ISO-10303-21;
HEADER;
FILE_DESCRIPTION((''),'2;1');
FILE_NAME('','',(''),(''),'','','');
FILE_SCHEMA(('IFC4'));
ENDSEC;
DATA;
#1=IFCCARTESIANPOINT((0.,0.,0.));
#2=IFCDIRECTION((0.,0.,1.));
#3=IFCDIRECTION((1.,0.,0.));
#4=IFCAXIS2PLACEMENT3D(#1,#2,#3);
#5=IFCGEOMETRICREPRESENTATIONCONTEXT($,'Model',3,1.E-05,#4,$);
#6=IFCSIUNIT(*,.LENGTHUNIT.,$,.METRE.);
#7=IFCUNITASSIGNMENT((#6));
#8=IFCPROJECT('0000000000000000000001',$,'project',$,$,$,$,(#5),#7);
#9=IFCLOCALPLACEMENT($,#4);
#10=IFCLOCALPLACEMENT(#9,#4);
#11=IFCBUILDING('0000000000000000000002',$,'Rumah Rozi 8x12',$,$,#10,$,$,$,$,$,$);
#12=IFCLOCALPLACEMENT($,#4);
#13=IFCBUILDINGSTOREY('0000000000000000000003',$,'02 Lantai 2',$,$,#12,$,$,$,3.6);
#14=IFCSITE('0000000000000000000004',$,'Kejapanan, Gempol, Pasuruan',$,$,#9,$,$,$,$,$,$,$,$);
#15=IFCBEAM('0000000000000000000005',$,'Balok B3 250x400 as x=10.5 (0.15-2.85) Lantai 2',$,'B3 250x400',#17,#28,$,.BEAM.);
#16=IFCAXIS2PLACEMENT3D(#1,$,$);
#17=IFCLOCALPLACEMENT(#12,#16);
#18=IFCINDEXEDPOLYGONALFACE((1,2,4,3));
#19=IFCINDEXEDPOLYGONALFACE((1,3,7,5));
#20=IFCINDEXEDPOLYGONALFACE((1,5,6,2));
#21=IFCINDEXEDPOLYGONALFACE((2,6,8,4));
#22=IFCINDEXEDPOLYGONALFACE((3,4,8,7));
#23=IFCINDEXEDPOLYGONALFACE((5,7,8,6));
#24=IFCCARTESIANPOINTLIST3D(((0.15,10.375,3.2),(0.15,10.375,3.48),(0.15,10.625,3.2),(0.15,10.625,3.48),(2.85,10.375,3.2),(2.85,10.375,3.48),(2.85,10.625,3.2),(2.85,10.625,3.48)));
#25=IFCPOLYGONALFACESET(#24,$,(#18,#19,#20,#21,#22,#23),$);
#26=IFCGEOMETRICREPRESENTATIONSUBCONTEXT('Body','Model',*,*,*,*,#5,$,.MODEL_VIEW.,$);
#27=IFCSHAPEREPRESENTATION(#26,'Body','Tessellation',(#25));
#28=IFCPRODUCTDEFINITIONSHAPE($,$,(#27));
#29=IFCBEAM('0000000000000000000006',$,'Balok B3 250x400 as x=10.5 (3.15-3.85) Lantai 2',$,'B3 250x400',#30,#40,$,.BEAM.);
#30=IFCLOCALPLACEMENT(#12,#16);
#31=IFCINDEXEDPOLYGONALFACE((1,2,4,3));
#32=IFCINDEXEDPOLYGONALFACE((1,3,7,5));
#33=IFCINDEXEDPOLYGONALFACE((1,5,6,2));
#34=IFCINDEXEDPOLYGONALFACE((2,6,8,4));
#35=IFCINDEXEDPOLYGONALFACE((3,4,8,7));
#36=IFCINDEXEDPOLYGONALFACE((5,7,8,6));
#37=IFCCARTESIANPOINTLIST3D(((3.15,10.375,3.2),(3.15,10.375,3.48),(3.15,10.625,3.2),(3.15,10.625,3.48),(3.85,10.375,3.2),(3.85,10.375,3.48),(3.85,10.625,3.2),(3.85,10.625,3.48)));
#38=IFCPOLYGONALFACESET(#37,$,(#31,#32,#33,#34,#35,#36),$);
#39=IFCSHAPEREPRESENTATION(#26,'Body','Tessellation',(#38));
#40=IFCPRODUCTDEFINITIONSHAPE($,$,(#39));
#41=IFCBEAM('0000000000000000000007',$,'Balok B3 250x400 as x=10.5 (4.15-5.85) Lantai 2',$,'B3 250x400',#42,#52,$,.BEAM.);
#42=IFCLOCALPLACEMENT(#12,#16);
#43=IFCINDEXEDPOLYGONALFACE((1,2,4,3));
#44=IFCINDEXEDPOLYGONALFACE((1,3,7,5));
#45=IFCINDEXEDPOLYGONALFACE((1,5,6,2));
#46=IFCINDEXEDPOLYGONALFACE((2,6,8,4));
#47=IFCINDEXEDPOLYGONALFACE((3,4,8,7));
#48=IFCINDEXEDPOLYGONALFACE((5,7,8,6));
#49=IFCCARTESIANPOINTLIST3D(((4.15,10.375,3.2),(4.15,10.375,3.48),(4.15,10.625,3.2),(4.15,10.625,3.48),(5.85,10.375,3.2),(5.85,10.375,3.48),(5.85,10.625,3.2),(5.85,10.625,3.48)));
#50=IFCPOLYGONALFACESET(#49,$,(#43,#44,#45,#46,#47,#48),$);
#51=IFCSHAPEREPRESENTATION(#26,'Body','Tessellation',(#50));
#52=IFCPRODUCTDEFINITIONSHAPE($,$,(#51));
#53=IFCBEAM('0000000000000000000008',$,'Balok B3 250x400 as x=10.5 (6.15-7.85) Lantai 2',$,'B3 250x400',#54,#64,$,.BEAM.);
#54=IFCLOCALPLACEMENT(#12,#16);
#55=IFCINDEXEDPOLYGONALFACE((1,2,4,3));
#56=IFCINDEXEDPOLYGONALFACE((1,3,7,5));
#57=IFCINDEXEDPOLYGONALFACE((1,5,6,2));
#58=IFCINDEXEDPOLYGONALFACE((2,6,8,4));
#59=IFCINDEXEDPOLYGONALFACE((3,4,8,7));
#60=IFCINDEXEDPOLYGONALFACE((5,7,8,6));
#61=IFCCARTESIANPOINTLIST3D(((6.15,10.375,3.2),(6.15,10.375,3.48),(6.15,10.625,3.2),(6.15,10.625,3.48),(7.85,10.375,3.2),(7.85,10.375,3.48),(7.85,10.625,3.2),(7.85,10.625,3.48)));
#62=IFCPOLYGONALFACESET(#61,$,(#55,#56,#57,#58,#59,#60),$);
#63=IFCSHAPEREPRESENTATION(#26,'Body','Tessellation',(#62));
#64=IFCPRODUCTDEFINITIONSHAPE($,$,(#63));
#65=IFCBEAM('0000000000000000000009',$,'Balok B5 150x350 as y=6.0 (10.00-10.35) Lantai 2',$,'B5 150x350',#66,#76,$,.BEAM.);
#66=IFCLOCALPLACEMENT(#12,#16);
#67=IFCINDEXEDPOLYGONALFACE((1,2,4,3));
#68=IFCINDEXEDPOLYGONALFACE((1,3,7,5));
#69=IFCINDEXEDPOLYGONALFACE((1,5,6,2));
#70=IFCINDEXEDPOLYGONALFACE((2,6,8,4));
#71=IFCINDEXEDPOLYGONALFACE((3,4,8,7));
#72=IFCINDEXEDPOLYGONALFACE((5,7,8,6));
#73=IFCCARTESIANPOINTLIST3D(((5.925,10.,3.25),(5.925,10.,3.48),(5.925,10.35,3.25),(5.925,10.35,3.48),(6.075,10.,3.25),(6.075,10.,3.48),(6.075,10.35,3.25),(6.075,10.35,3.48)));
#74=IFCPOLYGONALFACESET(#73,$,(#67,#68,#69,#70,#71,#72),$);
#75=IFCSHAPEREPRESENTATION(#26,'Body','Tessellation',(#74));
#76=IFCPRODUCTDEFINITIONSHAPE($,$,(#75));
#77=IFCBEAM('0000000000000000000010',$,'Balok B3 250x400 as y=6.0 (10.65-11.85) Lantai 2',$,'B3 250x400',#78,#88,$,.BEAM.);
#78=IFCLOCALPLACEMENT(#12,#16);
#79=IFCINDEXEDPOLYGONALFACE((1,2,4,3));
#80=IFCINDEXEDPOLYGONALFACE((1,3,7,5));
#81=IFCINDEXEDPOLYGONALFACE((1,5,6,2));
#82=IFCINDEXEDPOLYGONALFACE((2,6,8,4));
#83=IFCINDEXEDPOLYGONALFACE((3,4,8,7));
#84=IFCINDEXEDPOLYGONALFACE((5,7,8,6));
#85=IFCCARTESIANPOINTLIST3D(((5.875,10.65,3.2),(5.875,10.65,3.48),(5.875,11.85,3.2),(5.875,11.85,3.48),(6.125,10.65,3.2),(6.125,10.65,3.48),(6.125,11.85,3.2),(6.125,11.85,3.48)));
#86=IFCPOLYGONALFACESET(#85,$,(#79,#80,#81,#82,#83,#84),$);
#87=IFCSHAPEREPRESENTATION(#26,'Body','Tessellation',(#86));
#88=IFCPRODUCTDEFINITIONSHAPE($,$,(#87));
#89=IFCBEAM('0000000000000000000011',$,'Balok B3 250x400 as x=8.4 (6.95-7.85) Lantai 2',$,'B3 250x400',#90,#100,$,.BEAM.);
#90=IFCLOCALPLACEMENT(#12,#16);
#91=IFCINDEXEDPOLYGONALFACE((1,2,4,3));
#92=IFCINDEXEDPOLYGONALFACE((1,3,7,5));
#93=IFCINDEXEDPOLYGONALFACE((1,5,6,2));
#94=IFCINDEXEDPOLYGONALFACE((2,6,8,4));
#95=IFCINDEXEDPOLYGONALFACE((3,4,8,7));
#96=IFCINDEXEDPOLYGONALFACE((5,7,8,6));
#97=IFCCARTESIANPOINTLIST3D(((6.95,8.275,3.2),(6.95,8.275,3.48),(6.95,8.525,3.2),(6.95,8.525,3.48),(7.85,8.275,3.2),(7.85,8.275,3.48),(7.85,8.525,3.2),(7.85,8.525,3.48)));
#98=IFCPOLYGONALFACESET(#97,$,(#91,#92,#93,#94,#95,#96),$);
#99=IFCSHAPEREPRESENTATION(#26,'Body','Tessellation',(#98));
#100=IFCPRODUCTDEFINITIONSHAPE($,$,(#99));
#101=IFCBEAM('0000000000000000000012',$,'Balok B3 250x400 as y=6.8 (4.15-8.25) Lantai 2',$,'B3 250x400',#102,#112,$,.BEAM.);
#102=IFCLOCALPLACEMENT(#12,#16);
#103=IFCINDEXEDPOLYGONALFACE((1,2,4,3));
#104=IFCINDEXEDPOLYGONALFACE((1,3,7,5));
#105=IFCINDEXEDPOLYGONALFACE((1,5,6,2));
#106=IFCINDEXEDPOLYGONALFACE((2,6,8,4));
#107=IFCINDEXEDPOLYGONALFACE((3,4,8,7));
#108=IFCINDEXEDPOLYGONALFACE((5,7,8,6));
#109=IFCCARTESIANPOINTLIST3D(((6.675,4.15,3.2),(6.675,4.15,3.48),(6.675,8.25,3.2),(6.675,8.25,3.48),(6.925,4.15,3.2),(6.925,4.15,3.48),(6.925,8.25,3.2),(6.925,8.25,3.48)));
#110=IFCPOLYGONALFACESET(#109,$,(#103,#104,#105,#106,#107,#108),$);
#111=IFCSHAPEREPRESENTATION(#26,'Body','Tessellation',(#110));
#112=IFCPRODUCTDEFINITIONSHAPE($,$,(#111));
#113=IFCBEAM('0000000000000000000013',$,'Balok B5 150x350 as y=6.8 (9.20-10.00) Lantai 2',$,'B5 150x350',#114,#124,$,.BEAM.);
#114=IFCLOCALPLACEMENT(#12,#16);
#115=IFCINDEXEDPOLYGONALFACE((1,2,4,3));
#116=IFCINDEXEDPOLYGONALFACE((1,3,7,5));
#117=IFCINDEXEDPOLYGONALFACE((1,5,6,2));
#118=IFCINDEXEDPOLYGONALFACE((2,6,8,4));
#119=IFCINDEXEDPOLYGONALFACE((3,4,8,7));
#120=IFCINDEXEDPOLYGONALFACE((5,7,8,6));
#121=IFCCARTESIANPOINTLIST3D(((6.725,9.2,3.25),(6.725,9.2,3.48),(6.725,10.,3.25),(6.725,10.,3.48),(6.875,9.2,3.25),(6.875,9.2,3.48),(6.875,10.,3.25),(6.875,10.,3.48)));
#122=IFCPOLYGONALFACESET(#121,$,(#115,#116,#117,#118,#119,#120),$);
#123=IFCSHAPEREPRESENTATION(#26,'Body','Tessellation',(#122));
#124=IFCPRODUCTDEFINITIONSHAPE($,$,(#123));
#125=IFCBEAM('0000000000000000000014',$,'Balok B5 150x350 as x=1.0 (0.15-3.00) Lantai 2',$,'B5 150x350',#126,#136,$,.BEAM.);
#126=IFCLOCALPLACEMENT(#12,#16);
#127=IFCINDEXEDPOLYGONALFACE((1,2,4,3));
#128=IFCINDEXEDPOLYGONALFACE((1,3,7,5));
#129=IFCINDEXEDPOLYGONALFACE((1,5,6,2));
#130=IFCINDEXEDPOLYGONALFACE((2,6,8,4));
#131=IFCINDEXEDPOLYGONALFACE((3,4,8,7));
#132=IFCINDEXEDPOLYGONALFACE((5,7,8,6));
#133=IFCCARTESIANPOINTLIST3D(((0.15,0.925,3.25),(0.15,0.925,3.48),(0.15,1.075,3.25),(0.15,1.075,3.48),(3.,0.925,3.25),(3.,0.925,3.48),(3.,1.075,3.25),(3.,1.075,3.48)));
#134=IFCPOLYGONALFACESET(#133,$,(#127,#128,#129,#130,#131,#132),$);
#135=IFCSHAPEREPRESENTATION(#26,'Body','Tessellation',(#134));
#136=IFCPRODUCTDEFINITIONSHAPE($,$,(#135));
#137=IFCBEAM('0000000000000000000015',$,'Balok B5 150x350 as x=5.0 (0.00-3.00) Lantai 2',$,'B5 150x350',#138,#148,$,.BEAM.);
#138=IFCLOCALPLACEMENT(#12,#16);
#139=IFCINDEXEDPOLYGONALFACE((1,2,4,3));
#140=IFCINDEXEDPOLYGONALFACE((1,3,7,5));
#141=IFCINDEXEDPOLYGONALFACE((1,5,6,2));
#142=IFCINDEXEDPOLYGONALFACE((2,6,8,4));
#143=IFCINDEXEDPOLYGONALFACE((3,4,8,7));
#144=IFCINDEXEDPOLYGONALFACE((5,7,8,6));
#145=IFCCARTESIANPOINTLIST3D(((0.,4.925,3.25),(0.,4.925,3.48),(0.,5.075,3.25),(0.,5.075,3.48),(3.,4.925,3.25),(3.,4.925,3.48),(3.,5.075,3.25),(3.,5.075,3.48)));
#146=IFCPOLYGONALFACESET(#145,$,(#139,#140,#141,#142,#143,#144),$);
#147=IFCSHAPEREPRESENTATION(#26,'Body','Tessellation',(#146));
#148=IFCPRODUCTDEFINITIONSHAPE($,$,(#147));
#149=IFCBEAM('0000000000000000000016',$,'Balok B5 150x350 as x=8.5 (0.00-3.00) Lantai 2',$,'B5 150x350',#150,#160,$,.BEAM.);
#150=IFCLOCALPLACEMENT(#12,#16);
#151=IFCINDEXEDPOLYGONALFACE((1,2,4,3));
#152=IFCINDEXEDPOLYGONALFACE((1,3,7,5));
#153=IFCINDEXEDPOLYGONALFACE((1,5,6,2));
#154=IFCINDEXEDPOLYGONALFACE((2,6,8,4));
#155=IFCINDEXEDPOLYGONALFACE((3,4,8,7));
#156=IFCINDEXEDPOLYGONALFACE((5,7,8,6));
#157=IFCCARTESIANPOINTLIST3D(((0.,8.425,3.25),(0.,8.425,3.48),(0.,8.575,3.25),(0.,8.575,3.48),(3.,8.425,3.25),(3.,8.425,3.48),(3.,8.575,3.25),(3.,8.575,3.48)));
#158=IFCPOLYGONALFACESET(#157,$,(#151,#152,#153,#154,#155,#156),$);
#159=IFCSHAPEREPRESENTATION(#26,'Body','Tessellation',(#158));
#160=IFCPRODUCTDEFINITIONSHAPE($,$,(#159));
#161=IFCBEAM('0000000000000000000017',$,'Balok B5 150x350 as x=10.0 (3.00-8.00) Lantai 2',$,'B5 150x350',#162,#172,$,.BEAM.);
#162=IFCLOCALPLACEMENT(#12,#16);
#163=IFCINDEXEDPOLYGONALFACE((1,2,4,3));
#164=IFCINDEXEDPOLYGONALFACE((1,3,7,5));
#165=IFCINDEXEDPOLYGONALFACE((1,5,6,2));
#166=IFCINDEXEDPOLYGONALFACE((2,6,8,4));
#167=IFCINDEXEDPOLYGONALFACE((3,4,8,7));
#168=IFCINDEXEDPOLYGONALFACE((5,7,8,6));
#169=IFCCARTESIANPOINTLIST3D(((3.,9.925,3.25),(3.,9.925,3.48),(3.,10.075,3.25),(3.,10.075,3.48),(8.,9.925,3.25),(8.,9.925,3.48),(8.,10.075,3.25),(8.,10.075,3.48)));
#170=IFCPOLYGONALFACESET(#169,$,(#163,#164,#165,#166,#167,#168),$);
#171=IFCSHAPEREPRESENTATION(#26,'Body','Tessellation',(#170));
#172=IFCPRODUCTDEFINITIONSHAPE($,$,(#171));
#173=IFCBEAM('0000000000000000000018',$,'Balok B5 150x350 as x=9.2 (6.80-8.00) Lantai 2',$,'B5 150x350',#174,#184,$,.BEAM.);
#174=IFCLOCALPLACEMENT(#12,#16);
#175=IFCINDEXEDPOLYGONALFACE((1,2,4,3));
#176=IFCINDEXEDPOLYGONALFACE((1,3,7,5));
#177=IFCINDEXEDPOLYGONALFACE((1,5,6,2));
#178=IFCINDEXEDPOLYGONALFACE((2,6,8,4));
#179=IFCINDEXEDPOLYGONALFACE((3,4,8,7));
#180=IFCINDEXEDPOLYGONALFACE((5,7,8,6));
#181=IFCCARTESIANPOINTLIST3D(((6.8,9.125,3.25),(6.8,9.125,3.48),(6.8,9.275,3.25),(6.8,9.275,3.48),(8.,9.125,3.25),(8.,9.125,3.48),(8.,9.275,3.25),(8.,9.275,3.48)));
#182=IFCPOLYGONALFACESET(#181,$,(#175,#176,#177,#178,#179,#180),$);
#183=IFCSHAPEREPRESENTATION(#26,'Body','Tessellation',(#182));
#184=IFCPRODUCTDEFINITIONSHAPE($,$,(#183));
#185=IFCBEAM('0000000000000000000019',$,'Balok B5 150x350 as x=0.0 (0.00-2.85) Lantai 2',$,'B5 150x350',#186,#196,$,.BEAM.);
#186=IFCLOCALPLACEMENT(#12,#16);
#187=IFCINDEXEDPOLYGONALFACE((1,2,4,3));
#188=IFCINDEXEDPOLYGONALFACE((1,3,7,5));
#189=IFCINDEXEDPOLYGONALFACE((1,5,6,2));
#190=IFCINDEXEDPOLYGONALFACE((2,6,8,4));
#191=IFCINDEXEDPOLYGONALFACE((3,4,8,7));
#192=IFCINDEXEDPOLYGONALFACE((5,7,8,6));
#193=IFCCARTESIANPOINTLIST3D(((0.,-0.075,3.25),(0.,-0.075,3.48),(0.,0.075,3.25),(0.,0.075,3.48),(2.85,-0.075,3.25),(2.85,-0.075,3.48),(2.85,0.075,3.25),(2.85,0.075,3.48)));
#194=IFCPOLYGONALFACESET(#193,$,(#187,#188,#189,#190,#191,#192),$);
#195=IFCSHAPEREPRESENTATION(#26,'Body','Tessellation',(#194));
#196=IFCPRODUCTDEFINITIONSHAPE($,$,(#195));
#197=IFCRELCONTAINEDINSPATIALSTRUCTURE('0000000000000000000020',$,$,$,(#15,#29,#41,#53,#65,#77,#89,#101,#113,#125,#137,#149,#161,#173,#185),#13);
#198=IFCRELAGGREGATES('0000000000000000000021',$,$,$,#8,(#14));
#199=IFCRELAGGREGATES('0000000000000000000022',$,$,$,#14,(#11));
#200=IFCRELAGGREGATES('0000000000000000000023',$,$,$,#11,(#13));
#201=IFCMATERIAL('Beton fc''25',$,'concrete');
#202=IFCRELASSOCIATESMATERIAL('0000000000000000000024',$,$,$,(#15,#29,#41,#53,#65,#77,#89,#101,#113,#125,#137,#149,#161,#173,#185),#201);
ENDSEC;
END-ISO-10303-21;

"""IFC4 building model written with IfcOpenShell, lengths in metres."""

from ifc_helpers import new_model, si_unit, frame, origin_with_axes, place, context, subcontext, project, spatial, line, indexed_curve, outline, extrude, material, element, save


model = new_model("IFC4")

# Units and contexts
model_context = context("Model", 3, precision=1e-05, world=origin_with_axes())
body_context = subcontext(model_context, "Body", "Model", "MODEL_VIEW")
ifc_project = project(units=[si_unit("LENGTHUNIT", "METRE")], contexts=[model_context])

# Site, building, storey
site_placement = place(None, origin_with_axes())
site = spatial("IfcSite", under=ifc_project, at=site_placement, Name="Kejapanan, Gempol, Pasuruan")
building_placement = place(site_placement, origin_with_axes())
building = spatial("IfcBuilding", under=site, at=building_placement, Name="Rumah Rozi 8x12")
storey_placement = place(None, origin_with_axes())
storey = spatial("IfcBuildingStorey", under=building, at=storey_placement, Name="02 Lantai 2", Elevation=3.6)

# Beams
ifc_material_1 = material(Name="Beton fc'25", Category="concrete")
beam_1_placement = place(storey_placement, origin_with_axes())
element("IfcBeam", 1, at=beam_1_placement, inside=storey, material=ifc_material_1, Name="Balok B3 250x400 as x=10.5 (0.15-2.85) Lantai 2", ObjectType="B3 250x400", PredefinedType="BEAM", context=body_context, shape_type="SweptSolid", body=[
    extrude(outline(indexed_curve([(0.15, 10.375), (2.85, 10.375), (2.85, 10.625), (0.15, 10.625)], segments=[line(1, 2, 3, 4, 1)])), frame((0.0, 0.0, 3.2), z_axis=(0.0, 0.0, 1.0), x_axis=(1.0, 0.0, 0.0)), (0.0, 0.0, 1.0), 0.28),
])
beam_2_placement = place(storey_placement, origin_with_axes())
element("IfcBeam", 2, at=beam_2_placement, inside=storey, material=ifc_material_1, Name="Balok B3 250x400 as x=10.5 (3.15-3.85) Lantai 2", ObjectType="B3 250x400", PredefinedType="BEAM", context=body_context, shape_type="SweptSolid", body=[
    extrude(outline(indexed_curve([(3.15, 10.375), (3.85, 10.375), (3.85, 10.625), (3.15, 10.625)], segments=[line(1, 2, 3, 4, 1)])), frame((0.0, 0.0, 3.2), z_axis=(0.0, 0.0, 1.0), x_axis=(1.0, 0.0, 0.0)), (0.0, 0.0, 1.0), 0.28),
])
beam_3_placement = place(storey_placement, origin_with_axes())
element("IfcBeam", 3, at=beam_3_placement, inside=storey, material=ifc_material_1, Name="Balok B3 250x400 as x=10.5 (4.15-5.85) Lantai 2", ObjectType="B3 250x400", PredefinedType="BEAM", context=body_context, shape_type="SweptSolid", body=[
    extrude(outline(indexed_curve([(4.15, 10.375), (5.85, 10.375), (5.85, 10.625), (4.15, 10.625)], segments=[line(1, 2, 3, 4, 1)])), frame((0.0, 0.0, 3.2), z_axis=(0.0, 0.0, 1.0), x_axis=(1.0, 0.0, 0.0)), (0.0, 0.0, 1.0), 0.28),
])
beam_4_placement = place(storey_placement, origin_with_axes())
element("IfcBeam", 4, at=beam_4_placement, inside=storey, material=ifc_material_1, Name="Balok B3 250x400 as x=10.5 (6.15-7.85) Lantai 2", ObjectType="B3 250x400", PredefinedType="BEAM", context=body_context, shape_type="SweptSolid", body=[
    extrude(outline(indexed_curve([(6.15, 10.375), (7.85, 10.375), (7.85, 10.625), (6.15, 10.625)], segments=[line(1, 2, 3, 4, 1)])), frame((0.0, 0.0, 3.2), z_axis=(0.0, 0.0, 1.0), x_axis=(1.0, 0.0, 0.0)), (0.0, 0.0, 1.0), 0.28),
])
beam_5_placement = place(storey_placement, origin_with_axes())
element("IfcBeam", 5, at=beam_5_placement, inside=storey, material=ifc_material_1, Name="Balok B5 150x350 as y=6.0 (10.00-10.35) Lantai 2", ObjectType="B5 150x350", PredefinedType="BEAM", context=body_context, shape_type="SweptSolid", body=[
    extrude(outline(indexed_curve([(5.925, 10.0), (6.075, 10.0), (6.075, 10.35), (5.925, 10.35)], segments=[line(1, 2, 3, 4, 1)])), frame((0.0, 0.0, 3.25), z_axis=(0.0, 0.0, 1.0), x_axis=(1.0, 0.0, 0.0)), (0.0, 0.0, 1.0), 0.23),
])
beam_6_placement = place(storey_placement, origin_with_axes())
element("IfcBeam", 6, at=beam_6_placement, inside=storey, material=ifc_material_1, Name="Balok B3 250x400 as y=6.0 (10.65-11.85) Lantai 2", ObjectType="B3 250x400", PredefinedType="BEAM", context=body_context, shape_type="SweptSolid", body=[
    extrude(outline(indexed_curve([(5.875, 10.65), (6.125, 10.65), (6.125, 11.85), (5.875, 11.85)], segments=[line(1, 2, 3, 4, 1)])), frame((0.0, 0.0, 3.2), z_axis=(0.0, 0.0, 1.0), x_axis=(1.0, 0.0, 0.0)), (0.0, 0.0, 1.0), 0.28),
])
beam_7_placement = place(storey_placement, origin_with_axes())
element("IfcBeam", 7, at=beam_7_placement, inside=storey, material=ifc_material_1, Name="Balok B3 250x400 as x=8.4 (6.95-7.85) Lantai 2", ObjectType="B3 250x400", PredefinedType="BEAM", context=body_context, shape_type="SweptSolid", body=[
    extrude(outline(indexed_curve([(6.95, 8.275), (7.85, 8.275), (7.85, 8.525), (6.95, 8.525)], segments=[line(1, 2, 3, 4, 1)])), frame((0.0, 0.0, 3.2), z_axis=(0.0, 0.0, 1.0), x_axis=(1.0, 0.0, 0.0)), (0.0, 0.0, 1.0), 0.28),
])
beam_8_placement = place(storey_placement, origin_with_axes())
element("IfcBeam", 8, at=beam_8_placement, inside=storey, material=ifc_material_1, Name="Balok B3 250x400 as y=6.8 (4.15-8.25) Lantai 2", ObjectType="B3 250x400", PredefinedType="BEAM", context=body_context, shape_type="SweptSolid", body=[
    extrude(outline(indexed_curve([(6.675, 4.15), (6.925, 4.15), (6.925, 8.25), (6.675, 8.25)], segments=[line(1, 2, 3, 4, 1)])), frame((0.0, 0.0, 3.2), z_axis=(0.0, 0.0, 1.0), x_axis=(1.0, 0.0, 0.0)), (0.0, 0.0, 1.0), 0.28),
])
beam_9_placement = place(storey_placement, origin_with_axes())
element("IfcBeam", 9, at=beam_9_placement, inside=storey, material=ifc_material_1, Name="Balok B5 150x350 as y=6.8 (9.20-10.00) Lantai 2", ObjectType="B5 150x350", PredefinedType="BEAM", context=body_context, shape_type="SweptSolid", body=[
    extrude(outline(indexed_curve([(6.725, 9.2), (6.875, 9.2), (6.875, 10.0), (6.725, 10.0)], segments=[line(1, 2, 3, 4, 1)])), frame((0.0, 0.0, 3.25), z_axis=(0.0, 0.0, 1.0), x_axis=(1.0, 0.0, 0.0)), (0.0, 0.0, 1.0), 0.23),
])
beam_10_placement = place(storey_placement, origin_with_axes())
element("IfcBeam", 10, at=beam_10_placement, inside=storey, material=ifc_material_1, Name="Balok B5 150x350 as x=1.0 (0.15-3.00) Lantai 2", ObjectType="B5 150x350", PredefinedType="BEAM", context=body_context, shape_type="SweptSolid", body=[
    extrude(outline(indexed_curve([(0.15, 0.925), (3.0, 0.925), (3.0, 1.075), (0.15, 1.075)], segments=[line(1, 2, 3, 4, 1)])), frame((0.0, 0.0, 3.25), z_axis=(0.0, 0.0, 1.0), x_axis=(1.0, 0.0, 0.0)), (0.0, 0.0, 1.0), 0.23),
])
beam_11_placement = place(storey_placement, origin_with_axes())
element("IfcBeam", 11, at=beam_11_placement, inside=storey, material=ifc_material_1, Name="Balok B5 150x350 as x=5.0 (0.00-3.00) Lantai 2", ObjectType="B5 150x350", PredefinedType="BEAM", context=body_context, shape_type="SweptSolid", body=[
    extrude(outline(indexed_curve([(0.0, 4.925), (3.0, 4.925), (3.0, 5.075), (0.0, 5.075)], segments=[line(1, 2, 3, 4, 1)])), frame((0.0, 0.0, 3.25), z_axis=(0.0, 0.0, 1.0), x_axis=(1.0, 0.0, 0.0)), (0.0, 0.0, 1.0), 0.23),
])
beam_12_placement = place(storey_placement, origin_with_axes())
element("IfcBeam", 12, at=beam_12_placement, inside=storey, material=ifc_material_1, Name="Balok B5 150x350 as x=8.5 (0.00-3.00) Lantai 2", ObjectType="B5 150x350", PredefinedType="BEAM", context=body_context, shape_type="SweptSolid", body=[
    extrude(outline(indexed_curve([(0.0, 8.425), (3.0, 8.425), (3.0, 8.575), (0.0, 8.575)], segments=[line(1, 2, 3, 4, 1)])), frame((0.0, 0.0, 3.25), z_axis=(0.0, 0.0, 1.0), x_axis=(1.0, 0.0, 0.0)), (0.0, 0.0, 1.0), 0.23),
])
beam_13_placement = place(storey_placement, origin_with_axes())
element("IfcBeam", 13, at=beam_13_placement, inside=storey, material=ifc_material_1, Name="Balok B5 150x350 as x=10.0 (3.00-8.00) Lantai 2", ObjectType="B5 150x350", PredefinedType="BEAM", context=body_context, shape_type="SweptSolid", body=[
    extrude(outline(indexed_curve([(3.0, 9.925), (8.0, 9.925), (8.0, 10.075), (3.0, 10.075)], segments=[line(1, 2, 3, 4, 1)])), frame((0.0, 0.0, 3.25), z_axis=(0.0, 0.0, 1.0), x_axis=(1.0, 0.0, 0.0)), (0.0, 0.0, 1.0), 0.23),
])
beam_14_placement = place(storey_placement, origin_with_axes())
element("IfcBeam", 14, at=beam_14_placement, inside=storey, material=ifc_material_1, Name="Balok B5 150x350 as x=9.2 (6.80-8.00) Lantai 2", ObjectType="B5 150x350", PredefinedType="BEAM", context=body_context, shape_type="SweptSolid", body=[
    extrude(outline(indexed_curve([(6.8, 9.125), (8.0, 9.125), (8.0, 9.275), (6.8, 9.275)], segments=[line(1, 2, 3, 4, 1)])), frame((0.0, 0.0, 3.25), z_axis=(0.0, 0.0, 1.0), x_axis=(1.0, 0.0, 0.0)), (0.0, 0.0, 1.0), 0.23),
])
beam_15_placement = place(storey_placement, origin_with_axes())
element("IfcBeam", 15, at=beam_15_placement, inside=storey, material=ifc_material_1, Name="Balok B5 150x350 as x=0.0 (0.00-2.85) Lantai 2", ObjectType="B5 150x350", PredefinedType="BEAM", context=body_context, shape_type="SweptSolid", body=[
    extrude(outline(indexed_curve([(0.0, -0.075), (2.85, -0.075), (2.85, 0.075), (0.0, 0.075)], segments=[line(1, 2, 3, 4, 1)])), frame((0.0, 0.0, 3.25), z_axis=(0.0, 0.0, 1.0), x_axis=(1.0, 0.0, 0.0)), (0.0, 0.0, 1.0), 0.23),
])

save(model, "model.ifc")
